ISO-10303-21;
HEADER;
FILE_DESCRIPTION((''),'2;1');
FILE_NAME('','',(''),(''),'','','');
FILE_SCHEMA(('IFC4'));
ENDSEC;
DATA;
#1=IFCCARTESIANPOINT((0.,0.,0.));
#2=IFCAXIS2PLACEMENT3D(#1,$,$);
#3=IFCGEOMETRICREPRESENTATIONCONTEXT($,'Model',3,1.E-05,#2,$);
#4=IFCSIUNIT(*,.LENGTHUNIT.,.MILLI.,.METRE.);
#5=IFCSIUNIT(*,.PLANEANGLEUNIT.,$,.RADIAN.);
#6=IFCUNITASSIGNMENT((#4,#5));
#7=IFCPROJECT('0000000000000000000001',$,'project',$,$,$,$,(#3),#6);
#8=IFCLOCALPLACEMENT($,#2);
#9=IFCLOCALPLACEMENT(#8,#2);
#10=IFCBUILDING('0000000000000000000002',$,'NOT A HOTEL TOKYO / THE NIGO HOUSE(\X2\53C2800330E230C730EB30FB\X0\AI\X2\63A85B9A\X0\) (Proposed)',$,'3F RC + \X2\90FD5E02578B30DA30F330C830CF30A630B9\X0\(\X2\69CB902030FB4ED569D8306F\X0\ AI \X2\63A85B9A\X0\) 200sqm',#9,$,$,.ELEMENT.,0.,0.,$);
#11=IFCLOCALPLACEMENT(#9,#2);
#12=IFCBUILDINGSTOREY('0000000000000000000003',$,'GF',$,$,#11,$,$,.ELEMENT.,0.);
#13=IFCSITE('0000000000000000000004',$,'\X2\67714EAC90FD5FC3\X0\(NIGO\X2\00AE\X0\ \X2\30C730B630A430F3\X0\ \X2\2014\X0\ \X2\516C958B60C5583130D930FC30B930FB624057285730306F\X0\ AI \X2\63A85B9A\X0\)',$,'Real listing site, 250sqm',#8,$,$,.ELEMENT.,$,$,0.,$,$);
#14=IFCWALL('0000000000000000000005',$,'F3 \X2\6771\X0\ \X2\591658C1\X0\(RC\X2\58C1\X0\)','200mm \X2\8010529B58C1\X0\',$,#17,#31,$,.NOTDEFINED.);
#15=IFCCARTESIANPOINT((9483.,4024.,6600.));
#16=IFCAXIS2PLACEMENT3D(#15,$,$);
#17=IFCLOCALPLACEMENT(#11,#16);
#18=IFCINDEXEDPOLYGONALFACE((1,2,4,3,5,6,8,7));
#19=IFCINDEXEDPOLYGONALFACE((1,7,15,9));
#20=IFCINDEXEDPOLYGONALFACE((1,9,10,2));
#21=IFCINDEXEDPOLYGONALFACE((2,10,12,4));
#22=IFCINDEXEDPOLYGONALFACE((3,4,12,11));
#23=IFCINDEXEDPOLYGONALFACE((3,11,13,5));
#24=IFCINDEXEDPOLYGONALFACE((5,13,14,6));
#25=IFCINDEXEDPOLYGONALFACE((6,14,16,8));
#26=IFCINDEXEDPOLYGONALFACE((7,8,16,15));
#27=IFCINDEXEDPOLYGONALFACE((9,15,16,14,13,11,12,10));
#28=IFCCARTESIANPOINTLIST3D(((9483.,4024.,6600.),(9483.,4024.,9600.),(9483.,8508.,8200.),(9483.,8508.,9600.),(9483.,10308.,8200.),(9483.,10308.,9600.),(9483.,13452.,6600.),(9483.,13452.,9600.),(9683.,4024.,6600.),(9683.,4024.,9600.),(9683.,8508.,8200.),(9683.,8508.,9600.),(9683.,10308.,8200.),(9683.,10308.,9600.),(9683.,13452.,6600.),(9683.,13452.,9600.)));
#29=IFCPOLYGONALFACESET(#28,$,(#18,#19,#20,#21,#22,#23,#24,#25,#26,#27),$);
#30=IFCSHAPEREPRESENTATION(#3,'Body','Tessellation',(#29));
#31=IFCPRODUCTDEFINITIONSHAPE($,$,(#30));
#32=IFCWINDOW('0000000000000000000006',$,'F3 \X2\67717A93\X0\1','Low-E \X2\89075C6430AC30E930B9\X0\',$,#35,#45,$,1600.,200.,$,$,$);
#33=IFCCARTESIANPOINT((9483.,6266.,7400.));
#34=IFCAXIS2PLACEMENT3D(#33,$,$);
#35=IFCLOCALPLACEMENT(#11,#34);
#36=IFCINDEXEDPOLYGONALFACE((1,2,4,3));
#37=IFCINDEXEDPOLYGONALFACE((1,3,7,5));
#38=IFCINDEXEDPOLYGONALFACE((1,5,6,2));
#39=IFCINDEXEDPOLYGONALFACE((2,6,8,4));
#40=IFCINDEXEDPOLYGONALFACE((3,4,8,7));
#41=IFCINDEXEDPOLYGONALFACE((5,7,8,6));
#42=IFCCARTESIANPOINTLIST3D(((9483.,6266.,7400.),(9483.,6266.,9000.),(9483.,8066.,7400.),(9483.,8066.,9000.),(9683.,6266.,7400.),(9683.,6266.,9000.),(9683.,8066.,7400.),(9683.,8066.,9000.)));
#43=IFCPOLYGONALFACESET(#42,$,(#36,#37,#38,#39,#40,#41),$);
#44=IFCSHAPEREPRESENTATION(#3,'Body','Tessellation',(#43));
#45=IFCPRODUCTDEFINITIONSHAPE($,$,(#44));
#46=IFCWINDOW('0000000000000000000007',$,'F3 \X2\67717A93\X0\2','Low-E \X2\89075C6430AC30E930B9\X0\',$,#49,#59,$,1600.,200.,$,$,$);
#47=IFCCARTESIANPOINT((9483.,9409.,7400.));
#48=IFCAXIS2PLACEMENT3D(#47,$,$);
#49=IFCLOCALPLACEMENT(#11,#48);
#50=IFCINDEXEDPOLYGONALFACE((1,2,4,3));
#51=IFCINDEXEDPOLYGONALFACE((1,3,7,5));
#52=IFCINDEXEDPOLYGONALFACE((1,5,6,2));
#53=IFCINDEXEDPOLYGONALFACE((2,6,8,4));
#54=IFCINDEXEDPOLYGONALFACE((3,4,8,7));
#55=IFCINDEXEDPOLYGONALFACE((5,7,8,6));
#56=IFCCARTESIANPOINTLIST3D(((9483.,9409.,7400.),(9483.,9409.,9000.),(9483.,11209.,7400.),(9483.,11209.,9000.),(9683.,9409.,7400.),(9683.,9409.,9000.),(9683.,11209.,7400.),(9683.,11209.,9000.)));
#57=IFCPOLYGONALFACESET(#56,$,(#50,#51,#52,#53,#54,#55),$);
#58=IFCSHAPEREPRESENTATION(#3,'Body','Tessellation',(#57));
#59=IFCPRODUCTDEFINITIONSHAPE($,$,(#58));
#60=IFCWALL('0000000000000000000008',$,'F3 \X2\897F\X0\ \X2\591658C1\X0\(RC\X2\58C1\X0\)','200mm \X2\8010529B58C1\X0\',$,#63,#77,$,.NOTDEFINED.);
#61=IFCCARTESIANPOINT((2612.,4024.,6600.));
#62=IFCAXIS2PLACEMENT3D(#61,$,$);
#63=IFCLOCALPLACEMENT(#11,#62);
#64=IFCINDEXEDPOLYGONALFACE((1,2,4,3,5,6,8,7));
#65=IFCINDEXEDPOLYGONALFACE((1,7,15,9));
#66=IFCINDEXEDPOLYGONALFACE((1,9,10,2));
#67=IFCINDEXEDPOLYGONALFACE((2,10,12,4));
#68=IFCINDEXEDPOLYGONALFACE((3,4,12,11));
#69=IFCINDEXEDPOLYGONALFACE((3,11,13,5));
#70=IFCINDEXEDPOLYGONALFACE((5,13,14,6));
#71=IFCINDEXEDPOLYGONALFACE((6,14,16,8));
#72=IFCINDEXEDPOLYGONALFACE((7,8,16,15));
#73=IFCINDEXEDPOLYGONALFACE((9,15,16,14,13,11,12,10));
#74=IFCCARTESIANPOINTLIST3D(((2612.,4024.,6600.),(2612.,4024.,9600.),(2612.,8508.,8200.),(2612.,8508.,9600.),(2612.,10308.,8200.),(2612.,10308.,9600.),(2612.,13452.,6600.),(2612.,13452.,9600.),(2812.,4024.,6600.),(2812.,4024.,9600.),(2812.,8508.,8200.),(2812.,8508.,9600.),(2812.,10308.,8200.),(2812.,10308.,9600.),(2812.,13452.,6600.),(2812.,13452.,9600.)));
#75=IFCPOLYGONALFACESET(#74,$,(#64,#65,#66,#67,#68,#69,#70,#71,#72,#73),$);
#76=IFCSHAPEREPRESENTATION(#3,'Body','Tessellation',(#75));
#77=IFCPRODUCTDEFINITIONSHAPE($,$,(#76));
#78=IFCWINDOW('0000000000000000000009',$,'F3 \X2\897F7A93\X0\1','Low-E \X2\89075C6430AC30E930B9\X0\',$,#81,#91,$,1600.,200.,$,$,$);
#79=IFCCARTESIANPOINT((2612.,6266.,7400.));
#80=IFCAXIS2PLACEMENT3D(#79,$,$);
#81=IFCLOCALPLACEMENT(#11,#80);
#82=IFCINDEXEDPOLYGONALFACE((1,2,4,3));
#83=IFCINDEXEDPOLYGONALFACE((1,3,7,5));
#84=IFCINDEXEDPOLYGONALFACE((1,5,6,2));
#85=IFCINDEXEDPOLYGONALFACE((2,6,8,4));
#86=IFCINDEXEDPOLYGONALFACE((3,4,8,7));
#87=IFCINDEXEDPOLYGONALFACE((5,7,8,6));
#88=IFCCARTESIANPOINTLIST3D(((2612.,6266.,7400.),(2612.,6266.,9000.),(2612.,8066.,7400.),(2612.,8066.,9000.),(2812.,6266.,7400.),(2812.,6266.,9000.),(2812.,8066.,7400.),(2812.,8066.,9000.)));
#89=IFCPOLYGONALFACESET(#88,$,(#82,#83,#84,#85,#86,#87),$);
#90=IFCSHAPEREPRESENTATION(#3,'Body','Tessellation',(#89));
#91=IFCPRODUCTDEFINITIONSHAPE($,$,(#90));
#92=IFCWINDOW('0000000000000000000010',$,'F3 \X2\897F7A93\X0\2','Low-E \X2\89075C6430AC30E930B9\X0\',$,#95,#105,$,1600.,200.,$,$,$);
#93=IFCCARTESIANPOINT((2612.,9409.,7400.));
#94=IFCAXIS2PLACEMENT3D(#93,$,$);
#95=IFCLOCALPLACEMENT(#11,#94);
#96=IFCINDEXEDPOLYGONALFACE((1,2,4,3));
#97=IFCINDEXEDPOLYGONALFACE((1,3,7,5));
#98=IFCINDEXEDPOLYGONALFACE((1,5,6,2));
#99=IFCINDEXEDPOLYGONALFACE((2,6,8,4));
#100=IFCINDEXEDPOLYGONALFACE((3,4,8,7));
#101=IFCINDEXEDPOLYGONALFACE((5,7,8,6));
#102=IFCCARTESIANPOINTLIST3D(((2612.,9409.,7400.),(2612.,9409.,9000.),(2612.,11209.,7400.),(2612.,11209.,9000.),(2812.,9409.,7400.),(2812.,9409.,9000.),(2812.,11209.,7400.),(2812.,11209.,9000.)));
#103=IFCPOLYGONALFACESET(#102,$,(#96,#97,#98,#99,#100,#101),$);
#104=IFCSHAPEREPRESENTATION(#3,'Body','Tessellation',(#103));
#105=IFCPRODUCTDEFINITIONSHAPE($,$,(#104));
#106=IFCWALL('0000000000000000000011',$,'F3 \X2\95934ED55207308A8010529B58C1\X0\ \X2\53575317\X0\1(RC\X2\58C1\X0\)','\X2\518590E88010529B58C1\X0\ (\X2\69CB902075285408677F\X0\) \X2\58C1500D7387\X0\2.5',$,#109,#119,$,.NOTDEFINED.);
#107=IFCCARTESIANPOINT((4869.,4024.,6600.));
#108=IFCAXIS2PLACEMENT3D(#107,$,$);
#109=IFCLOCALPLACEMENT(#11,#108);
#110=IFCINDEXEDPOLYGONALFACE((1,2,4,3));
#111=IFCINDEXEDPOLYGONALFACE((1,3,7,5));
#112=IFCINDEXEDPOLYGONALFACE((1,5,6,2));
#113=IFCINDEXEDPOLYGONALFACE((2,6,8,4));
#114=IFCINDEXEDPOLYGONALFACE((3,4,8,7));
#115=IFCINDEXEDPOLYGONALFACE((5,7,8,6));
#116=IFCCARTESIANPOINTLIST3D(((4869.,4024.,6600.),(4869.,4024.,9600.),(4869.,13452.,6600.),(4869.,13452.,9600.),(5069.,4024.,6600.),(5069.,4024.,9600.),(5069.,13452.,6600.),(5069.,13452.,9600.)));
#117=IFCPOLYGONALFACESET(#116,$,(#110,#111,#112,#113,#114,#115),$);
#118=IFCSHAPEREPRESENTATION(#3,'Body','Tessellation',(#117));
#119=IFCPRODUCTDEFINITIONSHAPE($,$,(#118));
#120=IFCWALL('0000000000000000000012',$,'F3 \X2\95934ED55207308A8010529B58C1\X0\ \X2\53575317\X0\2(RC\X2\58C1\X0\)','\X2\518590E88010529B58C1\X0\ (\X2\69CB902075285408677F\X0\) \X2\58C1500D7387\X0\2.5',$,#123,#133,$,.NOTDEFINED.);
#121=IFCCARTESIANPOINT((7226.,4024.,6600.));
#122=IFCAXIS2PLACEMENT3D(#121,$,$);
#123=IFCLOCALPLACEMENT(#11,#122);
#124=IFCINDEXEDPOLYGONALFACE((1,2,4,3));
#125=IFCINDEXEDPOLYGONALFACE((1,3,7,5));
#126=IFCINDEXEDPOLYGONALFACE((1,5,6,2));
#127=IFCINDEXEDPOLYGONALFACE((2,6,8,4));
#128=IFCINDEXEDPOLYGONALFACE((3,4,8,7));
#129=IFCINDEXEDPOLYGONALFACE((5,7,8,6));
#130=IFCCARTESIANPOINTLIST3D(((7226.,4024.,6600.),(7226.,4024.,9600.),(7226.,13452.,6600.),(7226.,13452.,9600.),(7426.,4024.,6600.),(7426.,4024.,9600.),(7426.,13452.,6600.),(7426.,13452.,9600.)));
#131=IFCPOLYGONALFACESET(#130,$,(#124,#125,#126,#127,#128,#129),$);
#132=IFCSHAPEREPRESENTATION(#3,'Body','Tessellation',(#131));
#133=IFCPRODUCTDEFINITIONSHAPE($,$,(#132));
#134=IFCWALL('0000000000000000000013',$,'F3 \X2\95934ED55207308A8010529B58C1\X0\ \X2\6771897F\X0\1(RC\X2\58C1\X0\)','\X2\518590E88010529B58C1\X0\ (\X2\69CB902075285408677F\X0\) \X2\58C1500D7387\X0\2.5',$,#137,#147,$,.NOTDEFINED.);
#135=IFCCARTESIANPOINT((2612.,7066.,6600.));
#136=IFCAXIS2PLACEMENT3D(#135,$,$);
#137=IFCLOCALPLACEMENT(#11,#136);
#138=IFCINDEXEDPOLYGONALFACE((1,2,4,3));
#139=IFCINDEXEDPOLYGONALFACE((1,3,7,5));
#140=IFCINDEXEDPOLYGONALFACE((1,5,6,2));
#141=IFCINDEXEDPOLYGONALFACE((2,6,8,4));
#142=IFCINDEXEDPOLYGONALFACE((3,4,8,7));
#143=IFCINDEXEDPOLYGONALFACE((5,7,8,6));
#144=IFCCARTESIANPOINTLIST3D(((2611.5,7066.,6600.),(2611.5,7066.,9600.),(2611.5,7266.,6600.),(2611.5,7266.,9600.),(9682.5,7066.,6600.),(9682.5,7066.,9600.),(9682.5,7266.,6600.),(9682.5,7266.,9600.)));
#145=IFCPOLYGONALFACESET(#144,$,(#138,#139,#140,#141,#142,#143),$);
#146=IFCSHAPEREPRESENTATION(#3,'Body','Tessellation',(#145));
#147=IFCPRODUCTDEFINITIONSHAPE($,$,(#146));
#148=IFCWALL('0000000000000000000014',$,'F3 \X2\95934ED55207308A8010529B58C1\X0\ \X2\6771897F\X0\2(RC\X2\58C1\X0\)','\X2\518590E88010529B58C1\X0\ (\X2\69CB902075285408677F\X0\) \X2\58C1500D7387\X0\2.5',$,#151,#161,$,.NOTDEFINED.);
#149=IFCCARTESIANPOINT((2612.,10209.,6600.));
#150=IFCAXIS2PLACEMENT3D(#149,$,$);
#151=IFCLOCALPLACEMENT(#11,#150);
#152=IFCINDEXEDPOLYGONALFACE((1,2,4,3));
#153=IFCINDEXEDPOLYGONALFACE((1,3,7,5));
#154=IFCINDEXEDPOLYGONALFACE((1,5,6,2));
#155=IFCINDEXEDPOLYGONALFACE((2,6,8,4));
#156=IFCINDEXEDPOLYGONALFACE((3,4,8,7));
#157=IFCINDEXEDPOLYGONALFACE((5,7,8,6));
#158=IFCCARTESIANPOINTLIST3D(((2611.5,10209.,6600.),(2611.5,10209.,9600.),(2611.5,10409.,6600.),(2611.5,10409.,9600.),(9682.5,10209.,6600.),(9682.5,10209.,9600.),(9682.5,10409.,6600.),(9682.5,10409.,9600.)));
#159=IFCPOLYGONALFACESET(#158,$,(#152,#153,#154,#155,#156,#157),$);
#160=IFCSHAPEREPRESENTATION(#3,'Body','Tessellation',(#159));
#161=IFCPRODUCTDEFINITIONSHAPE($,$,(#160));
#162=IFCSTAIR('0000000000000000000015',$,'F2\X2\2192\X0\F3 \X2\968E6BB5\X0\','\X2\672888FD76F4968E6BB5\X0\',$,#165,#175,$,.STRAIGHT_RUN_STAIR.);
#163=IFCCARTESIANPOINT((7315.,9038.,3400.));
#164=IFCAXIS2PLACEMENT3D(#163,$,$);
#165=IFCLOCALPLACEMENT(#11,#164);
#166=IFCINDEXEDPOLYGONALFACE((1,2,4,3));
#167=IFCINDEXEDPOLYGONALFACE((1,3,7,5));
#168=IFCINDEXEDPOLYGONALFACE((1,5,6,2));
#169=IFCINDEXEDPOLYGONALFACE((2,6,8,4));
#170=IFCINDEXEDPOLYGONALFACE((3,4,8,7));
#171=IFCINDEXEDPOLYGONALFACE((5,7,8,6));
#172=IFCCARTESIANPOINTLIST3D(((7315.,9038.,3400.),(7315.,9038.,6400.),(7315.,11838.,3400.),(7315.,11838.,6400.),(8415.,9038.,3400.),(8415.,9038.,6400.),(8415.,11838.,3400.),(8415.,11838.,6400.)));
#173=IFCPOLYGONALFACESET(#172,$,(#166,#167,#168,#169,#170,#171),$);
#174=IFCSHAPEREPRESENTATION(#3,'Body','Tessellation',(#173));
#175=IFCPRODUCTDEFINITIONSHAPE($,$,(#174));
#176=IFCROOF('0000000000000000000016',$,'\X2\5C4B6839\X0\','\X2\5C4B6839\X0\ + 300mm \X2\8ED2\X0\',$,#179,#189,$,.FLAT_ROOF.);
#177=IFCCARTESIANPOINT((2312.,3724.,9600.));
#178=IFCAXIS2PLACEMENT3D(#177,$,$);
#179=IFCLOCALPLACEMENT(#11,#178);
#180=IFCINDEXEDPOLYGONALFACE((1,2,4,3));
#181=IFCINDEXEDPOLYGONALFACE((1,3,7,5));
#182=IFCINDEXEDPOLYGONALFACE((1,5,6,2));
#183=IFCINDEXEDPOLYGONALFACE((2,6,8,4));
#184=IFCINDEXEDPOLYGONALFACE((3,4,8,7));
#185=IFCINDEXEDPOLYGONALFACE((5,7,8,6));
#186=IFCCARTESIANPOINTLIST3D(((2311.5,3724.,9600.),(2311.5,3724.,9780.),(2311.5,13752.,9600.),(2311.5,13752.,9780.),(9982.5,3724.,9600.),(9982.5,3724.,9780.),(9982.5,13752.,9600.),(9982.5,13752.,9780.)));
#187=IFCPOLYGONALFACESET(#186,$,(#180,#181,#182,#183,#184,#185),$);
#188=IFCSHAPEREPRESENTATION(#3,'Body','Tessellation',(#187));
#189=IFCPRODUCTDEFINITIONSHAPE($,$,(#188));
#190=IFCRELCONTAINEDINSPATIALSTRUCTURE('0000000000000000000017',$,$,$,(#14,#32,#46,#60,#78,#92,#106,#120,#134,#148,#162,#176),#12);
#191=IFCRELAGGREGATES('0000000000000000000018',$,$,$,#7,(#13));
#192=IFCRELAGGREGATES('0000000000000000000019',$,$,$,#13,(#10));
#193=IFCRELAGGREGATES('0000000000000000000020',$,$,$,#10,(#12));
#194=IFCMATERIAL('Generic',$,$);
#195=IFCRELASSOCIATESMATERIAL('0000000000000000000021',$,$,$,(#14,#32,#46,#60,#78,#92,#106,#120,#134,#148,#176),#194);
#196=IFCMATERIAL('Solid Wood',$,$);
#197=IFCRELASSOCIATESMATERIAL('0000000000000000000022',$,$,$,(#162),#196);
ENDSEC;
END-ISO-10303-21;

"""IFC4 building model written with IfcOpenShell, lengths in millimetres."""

from ifc_helpers import new_model, si_unit, frame, frame_2d, origin, place, context, project, spatial, rectangle, extrude, material, element, fill, save


model = new_model("IFC4")

# Units and contexts
model_context = context("Model", 3, precision=1e-05, world=origin())
ifc_project = project(units=[si_unit("LENGTHUNIT", "METRE", prefix="MILLI"), si_unit("PLANEANGLEUNIT", "RADIAN")], contexts=[model_context])

# Site, building, storey
site_placement = place(None, origin())
site = spatial("IfcSite", under=ifc_project, at=site_placement, Name="東京都心(NIGO® デザイン — 公開情報ベース・所在地は AI 推定)", ObjectType="Real listing site, 250sqm", CompositionType="ELEMENT", RefElevation=0.0)
building_placement = place(site_placement, origin())
building = spatial("IfcBuilding", under=site, at=building_placement, Name="NOT A HOTEL TOKYO / THE NIGO HOUSE(参考モデル・AI推定) (Proposed)", ObjectType="3F RC + 都市型ペントハウス(構造・仕様は AI 推定) 200sqm", CompositionType="ELEMENT", ElevationOfRefHeight=0.0, ElevationOfTerrain=0.0)
storey_placement = place(building_placement, origin())
storey = spatial("IfcBuildingStorey", under=building, at=storey_placement, Name="GF", CompositionType="ELEMENT", Elevation=0.0)

# Shared definitions
ifc_material_1 = material(Name="Generic")

# Walls, openings, windows
wall_1_placement = place(storey_placement, frame((9483.0, 4024.0, 6600.0)))
wall_1 = element("IfcWall", 1, at=wall_1_placement, inside=storey, material=ifc_material_1, Name="F3 東 外壁(RC壁)", Description="200mm 耐力壁", PredefinedType="NOTDEFINED", context=model_context, shape_type="SweptSolid", body=[
    extrude(rectangle(XDim=200.0, YDim=9428.0, at=frame_2d((100.0, 4714.0))), frame((9483.0, 4024.0, 6600.0)), (0.0, 0.0, 1.0), 3000.0),
])
opening_1_placement = place(storey_placement, frame((9483.0, 6266.0, 7400.0)))
opening_1 = element("IfcOpeningElement", 2, at=opening_1_placement, cuts=wall_1, PredefinedType="NOTDEFINED", context=model_context, shape_type="SweptSolid", body=[
    extrude(rectangle(XDim=200.0, YDim=1800.0, at=frame_2d((100.0, 900.0))), frame((9483.0, 6266.0, 7400.0)), (0.0, 0.0, 1.0), 1600.0),
])
opening_2_placement = place(storey_placement, frame((9483.0, 9409.0, 7400.0)))
opening_2 = element("IfcOpeningElement", 3, at=opening_2_placement, cuts=wall_1, PredefinedType="NOTDEFINED", context=model_context, shape_type="SweptSolid", body=[
    extrude(rectangle(XDim=200.0, YDim=1800.0, at=frame_2d((100.0, 900.0))), frame((9483.0, 9409.0, 7400.0)), (0.0, 0.0, 1.0), 1600.0),
])
window_1_placement = place(storey_placement, frame((9483.0, 6266.0, 7400.0)))
window_1 = element("IfcWindow", 4, at=window_1_placement, inside=storey, material=ifc_material_1, Name="F3 東窓1", Description="Low-E 複層ガラス", OverallHeight=1600.0, OverallWidth=200.0, context=model_context, shape_type="SweptSolid", body=[
    extrude(rectangle(XDim=200.0, YDim=1800.0, at=frame_2d((100.0, 900.0))), frame((9483.0, 6266.0, 7400.0)), (0.0, 0.0, 1.0), 1600.0),
])
fill(opening_1, window_1)
window_2_placement = place(storey_placement, frame((9483.0, 9409.0, 7400.0)))
window_2 = element("IfcWindow", 5, at=window_2_placement, inside=storey, material=ifc_material_1, Name="F3 東窓2", Description="Low-E 複層ガラス", OverallHeight=1600.0, OverallWidth=200.0, context=model_context, shape_type="SweptSolid", body=[
    extrude(rectangle(XDim=200.0, YDim=1800.0, at=frame_2d((100.0, 900.0))), frame((9483.0, 9409.0, 7400.0)), (0.0, 0.0, 1.0), 1600.0),
])
fill(opening_2, window_2)
wall_2_placement = place(storey_placement, frame((2612.0, 4024.0, 6600.0)))
wall_2 = element("IfcWall", 6, at=wall_2_placement, inside=storey, material=ifc_material_1, Name="F3 西 外壁(RC壁)", Description="200mm 耐力壁", PredefinedType="NOTDEFINED", context=model_context, shape_type="SweptSolid", body=[
    extrude(rectangle(XDim=200.0, YDim=9428.0, at=frame_2d((100.0, 4714.0))), frame((2612.0, 4024.0, 6600.0)), (0.0, 0.0, 1.0), 3000.0),
])
opening_3_placement = place(storey_placement, frame((2612.0, 6266.0, 7400.0)))
opening_3 = element("IfcOpeningElement", 7, at=opening_3_placement, cuts=wall_2, PredefinedType="NOTDEFINED", context=model_context, shape_type="SweptSolid", body=[
    extrude(rectangle(XDim=200.0, YDim=1800.0, at=frame_2d((100.0, 900.0))), frame((2612.0, 6266.0, 7400.0)), (0.0, 0.0, 1.0), 1600.0),
])
opening_4_placement = place(storey_placement, frame((2612.0, 9409.0, 7400.0)))
opening_4 = element("IfcOpeningElement", 8, at=opening_4_placement, cuts=wall_2, PredefinedType="NOTDEFINED", context=model_context, shape_type="SweptSolid", body=[
    extrude(rectangle(XDim=200.0, YDim=1800.0, at=frame_2d((100.0, 900.0))), frame((2612.0, 9409.0, 7400.0)), (0.0, 0.0, 1.0), 1600.0),
])
window_3_placement = place(storey_placement, frame((2612.0, 6266.0, 7400.0)))
window_3 = element("IfcWindow", 9, at=window_3_placement, inside=storey, material=ifc_material_1, Name="F3 西窓1", Description="Low-E 複層ガラス", OverallHeight=1600.0, OverallWidth=200.0, context=model_context, shape_type="SweptSolid", body=[
    extrude(rectangle(XDim=200.0, YDim=1800.0, at=frame_2d((100.0, 900.0))), frame((2612.0, 6266.0, 7400.0)), (0.0, 0.0, 1.0), 1600.0),
])
fill(opening_3, window_3)
window_4_placement = place(storey_placement, frame((2612.0, 9409.0, 7400.0)))
window_4 = element("IfcWindow", 10, at=window_4_placement, inside=storey, material=ifc_material_1, Name="F3 西窓2", Description="Low-E 複層ガラス", OverallHeight=1600.0, OverallWidth=200.0, context=model_context, shape_type="SweptSolid", body=[
    extrude(rectangle(XDim=200.0, YDim=1800.0, at=frame_2d((100.0, 900.0))), frame((2612.0, 9409.0, 7400.0)), (0.0, 0.0, 1.0), 1600.0),
])
fill(opening_4, window_4)

# Walls
wall_3_placement = place(storey_placement, frame((4869.0, 4024.0, 6600.0)))
element("IfcWall", 11, at=wall_3_placement, inside=storey, material=ifc_material_1, Name="F3 間仕切り耐力壁 南北1(RC壁)", Description="内部耐力壁 (構造用合板) 壁倍率2.5", PredefinedType="NOTDEFINED", context=model_context, shape_type="SweptSolid", body=[
    extrude(rectangle(XDim=200.0, YDim=9428.0, at=frame_2d((100.0, 4714.0))), frame((4869.0, 4024.0, 6600.0)), (0.0, 0.0, 1.0), 3000.0),
])
wall_4_placement = place(storey_placement, frame((7226.0, 4024.0, 6600.0)))
element("IfcWall", 12, at=wall_4_placement, inside=storey, material=ifc_material_1, Name="F3 間仕切り耐力壁 南北2(RC壁)", Description="内部耐力壁 (構造用合板) 壁倍率2.5", PredefinedType="NOTDEFINED", context=model_context, shape_type="SweptSolid", body=[
    extrude(rectangle(XDim=200.0, YDim=9428.0, at=frame_2d((100.0, 4714.0))), frame((7226.0, 4024.0, 6600.0)), (0.0, 0.0, 1.0), 3000.0),
])
wall_5_placement = place(storey_placement, frame((2612.0, 7066.0, 6600.0)))
element("IfcWall", 13, at=wall_5_placement, inside=storey, material=ifc_material_1, Name="F3 間仕切り耐力壁 東西1(RC壁)", Description="内部耐力壁 (構造用合板) 壁倍率2.5", PredefinedType="NOTDEFINED", context=model_context, shape_type="SweptSolid", body=[
    extrude(rectangle(XDim=7071.0, YDim=200.0, at=frame_2d((3535.0, 100.0))), frame((2612.0, 7066.0, 6600.0)), (0.0, 0.0, 1.0), 3000.0),
])
wall_6_placement = place(storey_placement, frame((2612.0, 10209.0, 6600.0)))
element("IfcWall", 14, at=wall_6_placement, inside=storey, material=ifc_material_1, Name="F3 間仕切り耐力壁 東西2(RC壁)", Description="内部耐力壁 (構造用合板) 壁倍率2.5", PredefinedType="NOTDEFINED", context=model_context, shape_type="SweptSolid", body=[
    extrude(rectangle(XDim=7071.0, YDim=200.0, at=frame_2d((3535.0, 100.0))), frame((2612.0, 10209.0, 6600.0)), (0.0, 0.0, 1.0), 3000.0),
])

# Stair
ifc_material_2 = material(Name="Solid Wood")
stair_placement = place(storey_placement, frame((7315.0, 9038.0, 3400.0)))
element("IfcStair", 15, at=stair_placement, inside=storey, material=ifc_material_2, Name="F2→F3 階段", Description="木製直階段", PredefinedType="STRAIGHT_RUN_STAIR", context=model_context, shape_type="SweptSolid", body=[
    extrude(rectangle(XDim=1100.0, YDim=2800.0, at=frame_2d((550.0, 1400.0))), frame((7315.0, 9038.0, 3400.0)), (0.0, 0.0, 1.0), 3000.0),
])

# Roof
roof_placement = place(storey_placement, frame((2312.0, 3724.0, 9600.0)))
element("IfcRoof", 16, at=roof_placement, inside=storey, material=ifc_material_1, Name="屋根", Description="屋根 + 300mm 軒", PredefinedType="FLAT_ROOF", context=model_context, shape_type="SweptSolid", body=[
    extrude(rectangle(XDim=7671.0, YDim=10028.0, at=frame_2d((3835.0, 5014.0))), frame((2312.0, 3724.0, 9600.0)), (0.0, 0.0, 1.0), 180.0),
])

save(model, "model.ifc")
